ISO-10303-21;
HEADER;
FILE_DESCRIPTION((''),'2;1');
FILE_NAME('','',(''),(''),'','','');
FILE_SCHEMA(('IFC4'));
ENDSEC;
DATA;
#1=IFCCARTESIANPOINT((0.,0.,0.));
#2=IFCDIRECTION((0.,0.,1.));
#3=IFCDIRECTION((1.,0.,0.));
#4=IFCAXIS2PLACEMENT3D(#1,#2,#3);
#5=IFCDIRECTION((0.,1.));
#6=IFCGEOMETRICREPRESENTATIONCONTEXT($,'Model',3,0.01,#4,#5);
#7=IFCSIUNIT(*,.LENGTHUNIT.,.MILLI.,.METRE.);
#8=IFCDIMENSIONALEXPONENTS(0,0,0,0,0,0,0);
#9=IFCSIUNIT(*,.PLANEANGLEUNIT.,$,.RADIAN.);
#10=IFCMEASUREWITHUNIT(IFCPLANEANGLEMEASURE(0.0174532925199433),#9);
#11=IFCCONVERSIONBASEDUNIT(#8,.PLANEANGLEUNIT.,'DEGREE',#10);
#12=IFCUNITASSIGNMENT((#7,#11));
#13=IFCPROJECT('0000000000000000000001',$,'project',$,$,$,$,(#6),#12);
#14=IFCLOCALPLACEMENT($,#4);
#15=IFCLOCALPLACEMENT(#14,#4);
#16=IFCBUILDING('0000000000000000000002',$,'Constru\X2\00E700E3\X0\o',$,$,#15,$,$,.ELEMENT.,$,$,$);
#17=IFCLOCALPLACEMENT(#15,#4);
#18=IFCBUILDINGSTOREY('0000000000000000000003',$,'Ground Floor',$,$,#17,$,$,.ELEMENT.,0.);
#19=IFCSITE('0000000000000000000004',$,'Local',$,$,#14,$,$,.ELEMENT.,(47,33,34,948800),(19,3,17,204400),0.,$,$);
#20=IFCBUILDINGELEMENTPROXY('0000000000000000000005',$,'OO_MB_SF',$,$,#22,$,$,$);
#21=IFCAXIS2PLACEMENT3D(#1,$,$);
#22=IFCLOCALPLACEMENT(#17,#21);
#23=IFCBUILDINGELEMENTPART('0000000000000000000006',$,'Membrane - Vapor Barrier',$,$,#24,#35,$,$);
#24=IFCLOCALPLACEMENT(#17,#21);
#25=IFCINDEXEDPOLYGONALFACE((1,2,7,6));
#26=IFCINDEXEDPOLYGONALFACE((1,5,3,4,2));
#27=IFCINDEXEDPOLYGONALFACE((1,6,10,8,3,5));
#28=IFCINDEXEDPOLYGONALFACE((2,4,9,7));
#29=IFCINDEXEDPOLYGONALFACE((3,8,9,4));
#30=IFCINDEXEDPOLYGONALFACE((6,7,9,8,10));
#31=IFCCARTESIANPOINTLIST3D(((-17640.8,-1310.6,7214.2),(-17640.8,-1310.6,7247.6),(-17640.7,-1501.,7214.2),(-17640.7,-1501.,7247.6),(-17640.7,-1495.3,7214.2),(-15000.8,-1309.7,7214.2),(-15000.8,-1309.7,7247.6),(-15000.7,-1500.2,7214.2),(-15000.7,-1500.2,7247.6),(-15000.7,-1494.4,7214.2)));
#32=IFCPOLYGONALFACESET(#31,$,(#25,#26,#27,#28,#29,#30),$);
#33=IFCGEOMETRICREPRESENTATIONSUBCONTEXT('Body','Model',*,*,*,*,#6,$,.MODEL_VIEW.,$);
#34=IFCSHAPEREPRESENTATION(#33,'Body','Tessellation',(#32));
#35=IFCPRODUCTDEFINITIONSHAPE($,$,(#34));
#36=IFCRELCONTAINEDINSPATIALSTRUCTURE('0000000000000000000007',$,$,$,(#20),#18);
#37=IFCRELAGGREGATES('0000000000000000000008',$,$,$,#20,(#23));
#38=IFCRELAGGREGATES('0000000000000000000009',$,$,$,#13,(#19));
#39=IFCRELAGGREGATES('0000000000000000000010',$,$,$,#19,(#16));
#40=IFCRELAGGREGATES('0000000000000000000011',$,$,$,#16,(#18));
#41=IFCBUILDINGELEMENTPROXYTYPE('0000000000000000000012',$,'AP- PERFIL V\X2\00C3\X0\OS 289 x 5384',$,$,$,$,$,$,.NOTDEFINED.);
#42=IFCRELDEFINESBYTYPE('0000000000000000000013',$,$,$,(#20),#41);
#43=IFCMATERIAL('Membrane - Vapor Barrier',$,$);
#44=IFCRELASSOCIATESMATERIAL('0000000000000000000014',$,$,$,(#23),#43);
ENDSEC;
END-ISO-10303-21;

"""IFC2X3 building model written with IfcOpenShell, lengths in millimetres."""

from ifc_helpers import new_model, entity, si_unit, converted_unit, direction, frame, origin_with_axes, place, context, subcontext, project, spatial, polyline, outline, extrude, material, type_object, element, aggregate, save


model = new_model("IFC2X3")

# Units and contexts
model_context = context("Model", 3, precision=0.01, world=origin_with_axes(), true_north=direction((0.0, 1.0)))
body_context = subcontext(model_context, "Body", "Model", "MODEL_VIEW")
ifc_project = project(units=[si_unit("LENGTHUNIT", "METRE", prefix="MILLI"), converted_unit("PLANEANGLEUNIT", "DEGREE", entity("IfcPlaneAngleMeasure", 0.0174532925199433), si_unit("PLANEANGLEUNIT", "RADIAN"), dimensions=[0, 0, 0, 0, 0, 0, 0])], contexts=[model_context])

# Site, building, storey
site_placement = place(None, origin_with_axes())
site = spatial("IfcSite", under=ifc_project, at=site_placement, Name="Local", CompositionType="ELEMENT", RefLatitude=(47, 33, 34, 948800), RefLongitude=(19, 3, 17, 204400), RefElevation=0.0)
building_placement = place(site_placement, origin_with_axes())
building = spatial("IfcBuilding", under=site, at=building_placement, Name="Construção", CompositionType="ELEMENT")
storey_placement = place(building_placement, origin_with_axes())
storey = spatial("IfcBuildingStorey", under=building, at=storey_placement, Name="Ground Floor", CompositionType="ELEMENT", Elevation=0.0)

# Building element proxy, building element part
building_element_proxy_type = type_object("IfcBuildingElementProxyType", Name="AP- PERFIL VÃOS 289 x 5384", PredefinedType="NOTDEFINED")
proxy_1_placement = place(storey_placement, frame((-17640.8, -1310.6, 7247.6), z_axis=(0.0, 0.0, 1.0), x_axis=(0.000322, -1.0, 0.0)))
proxy_1 = element("IfcBuildingElementProxy", 1, at=proxy_1_placement, inside=storey, type_object=building_element_proxy_type, Name="OO_MB_SF")
ifc_material = material(Name="Membrane - Vapor Barrier")
building_element_part_1_placement = place(proxy_1_placement, origin_with_axes())
building_element_part_1 = element("IfcBuildingElementPart", 2, at=building_element_part_1_placement, material=ifc_material, Name="Membrane - Vapor Barrier", context=body_context, shape_type="SweptSolid", body=[
    extrude(outline(polyline([(190.4, 0.0), (0.0, 0.0), (0.0, -33.3), (184.7, -33.3), (190.4, -33.3), (190.4, 0.0)])), frame((0.0, 2640.0, 0.0), z_axis=(0.0, -1.0, 0.0), x_axis=(1.0, 0.0, 0.0)), (0.0, 0.0, 1.0), 2640.0),
])
aggregate(proxy_1, [building_element_part_1])

save(model, "model.ifc")
